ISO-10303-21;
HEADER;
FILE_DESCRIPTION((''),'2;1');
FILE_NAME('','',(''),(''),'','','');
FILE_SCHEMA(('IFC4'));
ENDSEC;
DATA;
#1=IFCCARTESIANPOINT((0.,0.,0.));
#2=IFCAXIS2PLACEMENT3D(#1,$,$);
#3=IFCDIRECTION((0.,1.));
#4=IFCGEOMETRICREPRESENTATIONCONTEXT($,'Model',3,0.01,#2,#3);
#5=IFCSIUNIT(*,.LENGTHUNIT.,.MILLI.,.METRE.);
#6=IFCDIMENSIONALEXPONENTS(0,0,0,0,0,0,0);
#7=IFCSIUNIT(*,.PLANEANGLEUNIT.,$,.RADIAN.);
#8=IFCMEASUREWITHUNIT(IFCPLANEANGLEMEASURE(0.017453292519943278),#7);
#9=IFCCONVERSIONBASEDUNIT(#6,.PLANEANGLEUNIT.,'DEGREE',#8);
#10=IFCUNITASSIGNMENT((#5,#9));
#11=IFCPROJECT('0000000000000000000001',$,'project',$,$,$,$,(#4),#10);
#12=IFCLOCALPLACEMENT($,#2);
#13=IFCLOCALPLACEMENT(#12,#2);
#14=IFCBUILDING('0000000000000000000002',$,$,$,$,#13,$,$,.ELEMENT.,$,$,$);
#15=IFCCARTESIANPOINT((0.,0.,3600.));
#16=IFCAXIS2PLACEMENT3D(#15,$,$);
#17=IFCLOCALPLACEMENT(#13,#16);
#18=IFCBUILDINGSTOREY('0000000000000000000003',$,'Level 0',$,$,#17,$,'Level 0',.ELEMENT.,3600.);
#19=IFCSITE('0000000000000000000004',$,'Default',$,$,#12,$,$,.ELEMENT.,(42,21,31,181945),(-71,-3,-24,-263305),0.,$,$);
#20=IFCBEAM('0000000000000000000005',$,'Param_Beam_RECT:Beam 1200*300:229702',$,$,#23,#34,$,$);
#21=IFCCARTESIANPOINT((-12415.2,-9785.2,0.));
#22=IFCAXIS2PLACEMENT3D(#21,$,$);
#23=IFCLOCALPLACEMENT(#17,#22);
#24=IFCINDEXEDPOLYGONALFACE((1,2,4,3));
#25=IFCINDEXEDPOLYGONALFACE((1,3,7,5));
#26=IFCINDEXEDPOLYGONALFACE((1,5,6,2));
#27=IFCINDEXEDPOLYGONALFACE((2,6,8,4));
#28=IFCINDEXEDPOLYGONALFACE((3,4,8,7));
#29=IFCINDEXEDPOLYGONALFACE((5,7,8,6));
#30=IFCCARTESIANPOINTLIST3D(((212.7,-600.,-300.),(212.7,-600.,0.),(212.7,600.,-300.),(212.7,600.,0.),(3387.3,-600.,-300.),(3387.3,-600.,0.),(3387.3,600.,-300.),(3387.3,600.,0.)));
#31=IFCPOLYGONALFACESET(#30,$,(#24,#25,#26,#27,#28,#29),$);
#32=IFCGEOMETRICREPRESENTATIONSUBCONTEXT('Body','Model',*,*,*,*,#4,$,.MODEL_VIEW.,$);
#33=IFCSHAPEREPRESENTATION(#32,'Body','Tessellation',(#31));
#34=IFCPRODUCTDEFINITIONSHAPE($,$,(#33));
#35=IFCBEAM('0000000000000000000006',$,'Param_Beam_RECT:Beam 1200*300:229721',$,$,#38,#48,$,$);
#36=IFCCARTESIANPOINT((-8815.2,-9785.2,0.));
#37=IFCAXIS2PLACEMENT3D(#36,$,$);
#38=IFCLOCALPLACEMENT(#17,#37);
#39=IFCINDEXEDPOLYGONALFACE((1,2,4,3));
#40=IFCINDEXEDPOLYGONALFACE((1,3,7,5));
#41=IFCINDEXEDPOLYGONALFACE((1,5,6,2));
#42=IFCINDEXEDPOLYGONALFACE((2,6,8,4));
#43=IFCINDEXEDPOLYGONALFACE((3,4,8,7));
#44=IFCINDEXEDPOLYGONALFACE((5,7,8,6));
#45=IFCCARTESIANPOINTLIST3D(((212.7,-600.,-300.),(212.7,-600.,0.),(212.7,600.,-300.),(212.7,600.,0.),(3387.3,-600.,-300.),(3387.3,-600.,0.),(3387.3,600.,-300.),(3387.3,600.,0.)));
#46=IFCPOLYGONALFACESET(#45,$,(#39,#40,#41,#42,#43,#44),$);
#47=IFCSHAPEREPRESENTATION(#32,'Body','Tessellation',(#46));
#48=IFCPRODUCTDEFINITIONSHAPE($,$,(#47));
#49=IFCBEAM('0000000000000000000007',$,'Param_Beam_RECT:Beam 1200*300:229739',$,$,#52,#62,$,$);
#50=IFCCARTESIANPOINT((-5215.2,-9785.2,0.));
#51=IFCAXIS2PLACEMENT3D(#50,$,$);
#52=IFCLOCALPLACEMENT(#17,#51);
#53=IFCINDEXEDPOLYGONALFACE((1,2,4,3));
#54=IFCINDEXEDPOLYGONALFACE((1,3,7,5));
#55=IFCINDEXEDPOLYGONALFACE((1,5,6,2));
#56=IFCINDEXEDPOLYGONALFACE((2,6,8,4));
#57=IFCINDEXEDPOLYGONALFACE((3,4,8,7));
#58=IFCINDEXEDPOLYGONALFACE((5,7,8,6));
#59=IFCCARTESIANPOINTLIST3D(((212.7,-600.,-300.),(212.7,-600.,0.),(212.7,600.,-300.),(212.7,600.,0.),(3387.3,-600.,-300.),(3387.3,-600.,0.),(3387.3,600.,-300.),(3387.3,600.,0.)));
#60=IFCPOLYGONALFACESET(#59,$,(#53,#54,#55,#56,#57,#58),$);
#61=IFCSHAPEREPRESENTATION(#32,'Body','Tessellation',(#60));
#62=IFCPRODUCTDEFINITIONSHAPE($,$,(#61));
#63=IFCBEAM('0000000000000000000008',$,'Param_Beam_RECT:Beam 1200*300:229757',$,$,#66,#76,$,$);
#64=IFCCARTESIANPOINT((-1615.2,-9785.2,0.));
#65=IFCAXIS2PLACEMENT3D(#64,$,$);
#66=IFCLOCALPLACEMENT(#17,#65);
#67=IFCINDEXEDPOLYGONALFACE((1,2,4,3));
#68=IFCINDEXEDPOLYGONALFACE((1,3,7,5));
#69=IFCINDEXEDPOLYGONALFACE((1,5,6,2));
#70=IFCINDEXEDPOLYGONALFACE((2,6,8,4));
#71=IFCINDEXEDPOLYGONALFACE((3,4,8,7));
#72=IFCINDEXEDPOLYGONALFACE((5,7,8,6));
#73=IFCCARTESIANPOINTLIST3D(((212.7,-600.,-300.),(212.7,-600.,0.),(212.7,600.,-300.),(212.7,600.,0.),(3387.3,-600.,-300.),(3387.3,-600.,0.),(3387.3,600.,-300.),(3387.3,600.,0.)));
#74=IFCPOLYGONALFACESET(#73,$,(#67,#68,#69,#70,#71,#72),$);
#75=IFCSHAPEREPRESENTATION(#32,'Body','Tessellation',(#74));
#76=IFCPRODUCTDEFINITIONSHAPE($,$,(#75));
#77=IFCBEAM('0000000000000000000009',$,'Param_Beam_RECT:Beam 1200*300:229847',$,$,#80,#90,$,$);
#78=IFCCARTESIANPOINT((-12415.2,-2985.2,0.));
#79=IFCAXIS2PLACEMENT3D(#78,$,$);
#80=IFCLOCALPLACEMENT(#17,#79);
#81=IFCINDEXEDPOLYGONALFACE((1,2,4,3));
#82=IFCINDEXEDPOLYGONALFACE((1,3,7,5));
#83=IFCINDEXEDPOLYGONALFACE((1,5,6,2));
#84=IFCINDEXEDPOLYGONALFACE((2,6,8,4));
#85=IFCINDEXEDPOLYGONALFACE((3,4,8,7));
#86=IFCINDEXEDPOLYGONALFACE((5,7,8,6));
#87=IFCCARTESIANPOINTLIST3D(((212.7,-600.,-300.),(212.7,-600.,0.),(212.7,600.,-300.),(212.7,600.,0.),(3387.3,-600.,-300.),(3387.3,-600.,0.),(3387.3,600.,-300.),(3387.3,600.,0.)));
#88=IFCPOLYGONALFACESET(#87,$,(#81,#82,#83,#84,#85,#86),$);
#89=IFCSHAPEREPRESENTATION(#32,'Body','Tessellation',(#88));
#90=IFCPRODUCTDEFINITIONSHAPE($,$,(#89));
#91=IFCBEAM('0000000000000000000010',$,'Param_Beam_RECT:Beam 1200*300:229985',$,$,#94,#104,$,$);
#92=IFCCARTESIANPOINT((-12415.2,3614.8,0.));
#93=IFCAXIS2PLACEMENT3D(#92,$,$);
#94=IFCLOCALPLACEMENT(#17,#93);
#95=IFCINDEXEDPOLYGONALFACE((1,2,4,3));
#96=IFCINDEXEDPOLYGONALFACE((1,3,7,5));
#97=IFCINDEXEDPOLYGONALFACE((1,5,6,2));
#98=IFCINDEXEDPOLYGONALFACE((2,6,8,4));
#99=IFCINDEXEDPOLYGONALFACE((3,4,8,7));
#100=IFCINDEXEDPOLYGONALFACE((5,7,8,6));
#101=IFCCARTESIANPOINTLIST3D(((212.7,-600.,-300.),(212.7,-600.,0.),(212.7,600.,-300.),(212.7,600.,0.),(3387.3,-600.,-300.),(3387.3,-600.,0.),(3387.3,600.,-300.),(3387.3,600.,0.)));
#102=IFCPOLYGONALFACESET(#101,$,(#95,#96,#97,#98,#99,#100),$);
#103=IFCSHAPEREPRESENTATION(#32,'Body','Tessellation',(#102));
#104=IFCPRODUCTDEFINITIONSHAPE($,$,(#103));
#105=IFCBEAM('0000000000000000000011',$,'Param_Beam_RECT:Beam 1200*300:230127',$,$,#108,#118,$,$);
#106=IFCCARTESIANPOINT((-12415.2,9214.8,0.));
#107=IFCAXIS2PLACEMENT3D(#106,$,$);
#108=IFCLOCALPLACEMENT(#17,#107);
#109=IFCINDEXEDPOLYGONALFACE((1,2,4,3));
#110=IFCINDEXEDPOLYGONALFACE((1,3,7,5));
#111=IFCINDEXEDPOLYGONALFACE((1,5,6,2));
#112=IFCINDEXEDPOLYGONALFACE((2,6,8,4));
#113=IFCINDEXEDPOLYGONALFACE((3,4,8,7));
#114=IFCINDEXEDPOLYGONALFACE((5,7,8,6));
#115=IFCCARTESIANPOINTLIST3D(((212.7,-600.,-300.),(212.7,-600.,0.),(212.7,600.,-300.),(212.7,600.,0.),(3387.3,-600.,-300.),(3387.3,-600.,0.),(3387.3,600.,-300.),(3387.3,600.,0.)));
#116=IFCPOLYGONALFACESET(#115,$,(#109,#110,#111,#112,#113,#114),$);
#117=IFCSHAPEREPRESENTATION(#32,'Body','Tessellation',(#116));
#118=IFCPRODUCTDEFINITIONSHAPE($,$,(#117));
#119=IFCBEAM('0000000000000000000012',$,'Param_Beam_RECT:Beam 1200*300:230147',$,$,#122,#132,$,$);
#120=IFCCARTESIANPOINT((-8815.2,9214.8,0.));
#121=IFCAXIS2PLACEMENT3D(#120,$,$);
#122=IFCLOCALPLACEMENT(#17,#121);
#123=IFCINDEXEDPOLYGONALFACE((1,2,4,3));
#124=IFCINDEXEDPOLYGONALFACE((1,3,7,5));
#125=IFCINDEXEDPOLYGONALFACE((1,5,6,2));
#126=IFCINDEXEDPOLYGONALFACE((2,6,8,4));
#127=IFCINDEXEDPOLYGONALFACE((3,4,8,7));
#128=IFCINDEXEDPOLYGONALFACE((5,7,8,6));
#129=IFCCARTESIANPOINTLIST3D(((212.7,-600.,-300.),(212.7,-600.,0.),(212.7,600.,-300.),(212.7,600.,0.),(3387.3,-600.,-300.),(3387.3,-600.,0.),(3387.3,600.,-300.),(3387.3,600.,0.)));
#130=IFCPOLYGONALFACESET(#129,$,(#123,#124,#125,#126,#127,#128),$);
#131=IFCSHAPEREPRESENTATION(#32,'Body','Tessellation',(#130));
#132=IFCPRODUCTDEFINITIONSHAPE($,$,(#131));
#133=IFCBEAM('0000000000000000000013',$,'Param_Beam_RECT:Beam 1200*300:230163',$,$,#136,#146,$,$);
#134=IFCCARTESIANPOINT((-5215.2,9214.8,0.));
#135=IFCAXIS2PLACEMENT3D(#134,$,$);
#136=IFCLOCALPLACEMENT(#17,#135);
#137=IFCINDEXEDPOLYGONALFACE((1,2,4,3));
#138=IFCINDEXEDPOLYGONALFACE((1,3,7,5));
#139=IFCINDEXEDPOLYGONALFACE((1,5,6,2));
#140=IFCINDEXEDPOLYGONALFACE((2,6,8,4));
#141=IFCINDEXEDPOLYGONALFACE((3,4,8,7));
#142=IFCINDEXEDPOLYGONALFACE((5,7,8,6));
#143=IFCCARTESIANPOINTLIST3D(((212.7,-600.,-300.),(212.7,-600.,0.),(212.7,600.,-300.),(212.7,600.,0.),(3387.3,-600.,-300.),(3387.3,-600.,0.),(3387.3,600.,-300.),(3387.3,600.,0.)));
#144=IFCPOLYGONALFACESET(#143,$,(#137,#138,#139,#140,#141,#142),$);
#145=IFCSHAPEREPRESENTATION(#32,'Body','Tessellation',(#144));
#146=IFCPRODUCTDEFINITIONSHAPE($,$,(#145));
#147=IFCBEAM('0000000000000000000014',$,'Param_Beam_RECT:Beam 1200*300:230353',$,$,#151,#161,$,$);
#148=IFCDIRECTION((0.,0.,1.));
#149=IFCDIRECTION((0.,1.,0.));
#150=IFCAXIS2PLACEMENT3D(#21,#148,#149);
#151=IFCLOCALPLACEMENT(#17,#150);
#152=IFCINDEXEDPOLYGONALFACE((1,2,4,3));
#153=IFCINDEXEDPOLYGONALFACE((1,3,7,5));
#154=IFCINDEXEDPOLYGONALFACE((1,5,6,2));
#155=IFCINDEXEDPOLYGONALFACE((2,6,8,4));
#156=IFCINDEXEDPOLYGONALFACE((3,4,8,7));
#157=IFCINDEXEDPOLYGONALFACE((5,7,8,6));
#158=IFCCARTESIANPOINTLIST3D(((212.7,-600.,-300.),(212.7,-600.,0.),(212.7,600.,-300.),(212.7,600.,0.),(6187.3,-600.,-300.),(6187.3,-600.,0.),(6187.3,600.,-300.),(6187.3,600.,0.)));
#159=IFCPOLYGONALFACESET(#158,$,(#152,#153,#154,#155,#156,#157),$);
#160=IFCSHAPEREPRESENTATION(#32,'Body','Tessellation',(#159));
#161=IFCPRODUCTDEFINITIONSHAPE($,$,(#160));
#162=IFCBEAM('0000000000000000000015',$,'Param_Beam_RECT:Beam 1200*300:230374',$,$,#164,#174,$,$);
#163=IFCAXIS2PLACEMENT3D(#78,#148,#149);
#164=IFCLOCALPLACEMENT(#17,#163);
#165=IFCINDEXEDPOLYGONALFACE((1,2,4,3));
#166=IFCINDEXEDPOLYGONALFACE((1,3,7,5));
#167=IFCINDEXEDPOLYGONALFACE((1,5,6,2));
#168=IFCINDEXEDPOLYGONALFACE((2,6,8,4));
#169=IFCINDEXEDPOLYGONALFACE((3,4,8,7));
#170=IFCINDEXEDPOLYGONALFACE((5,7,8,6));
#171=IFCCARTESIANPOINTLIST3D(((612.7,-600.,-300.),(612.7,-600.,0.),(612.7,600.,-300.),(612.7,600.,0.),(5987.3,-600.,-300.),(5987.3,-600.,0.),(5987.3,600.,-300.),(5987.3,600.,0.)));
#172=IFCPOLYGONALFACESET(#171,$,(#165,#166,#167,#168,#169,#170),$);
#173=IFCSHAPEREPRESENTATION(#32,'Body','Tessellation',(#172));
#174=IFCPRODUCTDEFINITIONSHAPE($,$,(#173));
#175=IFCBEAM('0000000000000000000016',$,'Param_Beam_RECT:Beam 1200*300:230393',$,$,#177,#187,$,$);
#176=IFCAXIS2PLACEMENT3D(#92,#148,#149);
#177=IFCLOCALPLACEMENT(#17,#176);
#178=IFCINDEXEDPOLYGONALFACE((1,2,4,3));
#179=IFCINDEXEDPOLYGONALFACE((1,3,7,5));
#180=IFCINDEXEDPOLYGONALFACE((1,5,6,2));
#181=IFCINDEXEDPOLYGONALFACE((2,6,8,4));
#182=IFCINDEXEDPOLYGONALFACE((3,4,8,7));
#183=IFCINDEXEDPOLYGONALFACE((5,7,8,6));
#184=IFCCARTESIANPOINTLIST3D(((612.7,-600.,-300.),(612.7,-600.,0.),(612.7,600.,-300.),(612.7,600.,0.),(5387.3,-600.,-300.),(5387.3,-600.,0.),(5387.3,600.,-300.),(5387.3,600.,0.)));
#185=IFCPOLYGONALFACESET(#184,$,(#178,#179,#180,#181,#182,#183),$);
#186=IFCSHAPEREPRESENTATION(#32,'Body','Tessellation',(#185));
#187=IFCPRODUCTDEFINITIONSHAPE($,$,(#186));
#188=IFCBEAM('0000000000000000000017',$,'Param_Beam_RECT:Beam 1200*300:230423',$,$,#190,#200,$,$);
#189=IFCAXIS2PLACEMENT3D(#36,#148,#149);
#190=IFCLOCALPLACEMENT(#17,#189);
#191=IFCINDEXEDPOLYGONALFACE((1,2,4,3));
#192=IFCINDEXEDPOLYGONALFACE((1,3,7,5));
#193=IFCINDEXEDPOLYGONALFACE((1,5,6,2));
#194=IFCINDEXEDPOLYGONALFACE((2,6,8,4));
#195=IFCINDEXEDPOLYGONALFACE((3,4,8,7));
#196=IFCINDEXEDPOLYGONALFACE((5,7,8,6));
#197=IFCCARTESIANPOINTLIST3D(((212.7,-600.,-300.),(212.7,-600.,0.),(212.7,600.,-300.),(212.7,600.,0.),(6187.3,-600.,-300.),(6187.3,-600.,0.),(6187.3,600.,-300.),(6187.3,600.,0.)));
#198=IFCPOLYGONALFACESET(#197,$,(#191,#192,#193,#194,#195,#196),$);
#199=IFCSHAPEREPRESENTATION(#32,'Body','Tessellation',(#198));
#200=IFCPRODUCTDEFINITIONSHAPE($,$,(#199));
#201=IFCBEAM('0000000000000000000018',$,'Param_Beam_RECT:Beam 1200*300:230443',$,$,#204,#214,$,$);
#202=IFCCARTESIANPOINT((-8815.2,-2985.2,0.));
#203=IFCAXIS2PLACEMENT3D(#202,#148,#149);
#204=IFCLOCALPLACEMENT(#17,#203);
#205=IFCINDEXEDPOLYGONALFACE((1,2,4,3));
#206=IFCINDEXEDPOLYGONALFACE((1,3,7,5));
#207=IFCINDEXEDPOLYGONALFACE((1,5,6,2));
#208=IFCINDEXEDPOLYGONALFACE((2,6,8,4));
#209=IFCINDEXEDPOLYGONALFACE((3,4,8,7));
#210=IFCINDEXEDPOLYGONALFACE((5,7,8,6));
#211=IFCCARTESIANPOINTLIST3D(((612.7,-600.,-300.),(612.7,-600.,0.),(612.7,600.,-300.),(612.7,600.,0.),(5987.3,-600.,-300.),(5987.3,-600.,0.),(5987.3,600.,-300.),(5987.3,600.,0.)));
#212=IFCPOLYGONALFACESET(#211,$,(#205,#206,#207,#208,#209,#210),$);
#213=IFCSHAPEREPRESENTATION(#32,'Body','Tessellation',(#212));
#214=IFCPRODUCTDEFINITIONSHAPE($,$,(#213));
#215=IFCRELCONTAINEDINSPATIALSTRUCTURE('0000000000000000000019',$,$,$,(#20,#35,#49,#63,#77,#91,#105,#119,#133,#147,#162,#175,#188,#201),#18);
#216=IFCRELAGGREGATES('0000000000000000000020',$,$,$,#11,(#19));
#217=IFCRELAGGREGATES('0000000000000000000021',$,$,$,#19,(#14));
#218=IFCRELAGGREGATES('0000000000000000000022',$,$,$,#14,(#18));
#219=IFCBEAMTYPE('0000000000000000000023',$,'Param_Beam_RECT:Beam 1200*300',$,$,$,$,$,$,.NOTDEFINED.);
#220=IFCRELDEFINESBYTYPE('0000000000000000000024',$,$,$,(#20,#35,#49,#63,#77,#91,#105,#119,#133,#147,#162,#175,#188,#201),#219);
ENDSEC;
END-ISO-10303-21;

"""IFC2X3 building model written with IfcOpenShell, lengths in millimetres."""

from ifc_helpers import new_model, entity, si_unit, converted_unit, direction, frame, frame_2d, origin, place, context, subcontext, project, spatial, rectangle, extrude, type_object, element, save


model = new_model("IFC2X3")

# Units and contexts
model_context = context("Model", 3, precision=0.01, world=origin(), true_north=direction((0.0, 1.0)))
body_context = subcontext(model_context, "Body", "Model", "MODEL_VIEW")
ifc_project = project(units=[si_unit("LENGTHUNIT", "METRE", prefix="MILLI"), converted_unit("PLANEANGLEUNIT", "DEGREE", entity("IfcPlaneAngleMeasure", 0.017453292519943278), si_unit("PLANEANGLEUNIT", "RADIAN"), dimensions=[0, 0, 0, 0, 0, 0, 0])], contexts=[model_context])

# Site, building, storey
site_placement = place(None, origin())
site = spatial("IfcSite", under=ifc_project, at=site_placement, Name="Default", CompositionType="ELEMENT", RefLatitude=(42, 21, 31, 181945), RefLongitude=(-71, -3, -24, -263305), RefElevation=0.0)
building_placement = place(site_placement, origin())
building = spatial("IfcBuilding", under=site, at=building_placement, CompositionType="ELEMENT")
storey_placement = place(building_placement, frame((0.0, 0.0, 3600.0)))
storey = spatial("IfcBuildingStorey", under=building, at=storey_placement, Name="Level 0", LongName="Level 0", CompositionType="ELEMENT", Elevation=3600.0)

# Beams
beam_type_1 = type_object("IfcBeamType", Name="Param_Beam_RECT:Beam 1200*300", PredefinedType="NOTDEFINED")
beam_1_placement = place(storey_placement, frame((-12415.2, -9785.2, 0.0)))
element("IfcBeam", 1, at=beam_1_placement, inside=storey, type_object=beam_type_1, Name="Param_Beam_RECT:Beam 1200*300:229702", context=body_context, shape_type="SweptSolid", body=[
    extrude(rectangle(XDim=300.0, YDim=1200.0, at=frame_2d((0.0, 0.0), x_axis=(1.0, 0.0))), frame((212.7, 0.0, -150.0), z_axis=(1.0, 0.0, 0.0), x_axis=(0.0, 0.0, -1.0)), (0.0, 0.0, 1.0), 3174.6),
])
beam_2_placement = place(storey_placement, frame((-8815.2, -9785.2, 0.0)))
element("IfcBeam", 2, at=beam_2_placement, inside=storey, type_object=beam_type_1, Name="Param_Beam_RECT:Beam 1200*300:229721", context=body_context, shape_type="SweptSolid", body=[
    extrude(rectangle(XDim=300.0, YDim=1200.0, at=frame_2d((0.0, 0.0), x_axis=(1.0, 0.0))), frame((212.7, 0.0, -150.0), z_axis=(1.0, 0.0, 0.0), x_axis=(0.0, 0.0, -1.0)), (0.0, 0.0, 1.0), 3174.6),
])
beam_3_placement = place(storey_placement, frame((-5215.2, -9785.2, 0.0)))
element("IfcBeam", 3, at=beam_3_placement, inside=storey, type_object=beam_type_1, Name="Param_Beam_RECT:Beam 1200*300:229739", context=body_context, shape_type="SweptSolid", body=[
    extrude(rectangle(XDim=300.0, YDim=1200.0, at=frame_2d((0.0, 0.0), x_axis=(1.0, 0.0))), frame((212.7, 0.0, -150.0), z_axis=(1.0, 0.0, 0.0), x_axis=(0.0, 0.0, -1.0)), (0.0, 0.0, 1.0), 3174.6),
])
beam_4_placement = place(storey_placement, frame((-1615.2, -9785.2, 0.0)))
element("IfcBeam", 4, at=beam_4_placement, inside=storey, type_object=beam_type_1, Name="Param_Beam_RECT:Beam 1200*300:229757", context=body_context, shape_type="SweptSolid", body=[
    extrude(rectangle(XDim=300.0, YDim=1200.0, at=frame_2d((0.0, 0.0), x_axis=(1.0, 0.0))), frame((212.7, 0.0, -150.0), z_axis=(1.0, 0.0, 0.0), x_axis=(0.0, 0.0, -1.0)), (0.0, 0.0, 1.0), 3174.6),
])
beam_5_placement = place(storey_placement, frame((-12415.2, -2985.2, 0.0)))
element("IfcBeam", 5, at=beam_5_placement, inside=storey, type_object=beam_type_1, Name="Param_Beam_RECT:Beam 1200*300:229847", context=body_context, shape_type="SweptSolid", body=[
    extrude(rectangle(XDim=300.0, YDim=1200.0, at=frame_2d((0.0, 0.0), x_axis=(1.0, 0.0))), frame((212.7, 0.0, -150.0), z_axis=(1.0, 0.0, 0.0), x_axis=(0.0, 0.0, -1.0)), (0.0, 0.0, 1.0), 3174.6),
])
beam_6_placement = place(storey_placement, frame((-12415.2, 3614.8, 0.0)))
element("IfcBeam", 6, at=beam_6_placement, inside=storey, type_object=beam_type_1, Name="Param_Beam_RECT:Beam 1200*300:229985", context=body_context, shape_type="SweptSolid", body=[
    extrude(rectangle(XDim=300.0, YDim=1200.0, at=frame_2d((0.0, 0.0), x_axis=(1.0, 0.0))), frame((212.7, 0.0, -150.0), z_axis=(1.0, 0.0, 0.0), x_axis=(0.0, 0.0, -1.0)), (0.0, 0.0, 1.0), 3174.6),
])
beam_7_placement = place(storey_placement, frame((-12415.2, 9214.8, 0.0)))
element("IfcBeam", 7, at=beam_7_placement, inside=storey, type_object=beam_type_1, Name="Param_Beam_RECT:Beam 1200*300:230127", context=body_context, shape_type="SweptSolid", body=[
    extrude(rectangle(XDim=300.0, YDim=1200.0, at=frame_2d((0.0, 0.0), x_axis=(1.0, 0.0))), frame((212.7, 0.0, -150.0), z_axis=(1.0, 0.0, 0.0), x_axis=(0.0, 0.0, -1.0)), (0.0, 0.0, 1.0), 3174.6),
])
for number, where, name in (
    (8, (-8815.2, 9214.8, 0.0), "Param_Beam_RECT:Beam 1200*300:230147"),
    (9, (-5215.2, 9214.8, 0.0), "Param_Beam_RECT:Beam 1200*300:230163"),
):
    element("IfcBeam", number, at=place(storey_placement, frame(where)), inside=storey, type_object=beam_type_1, Name=name, context=body_context, shape_type="SweptSolid", body=[
        extrude(rectangle(XDim=300.0, YDim=1200.0, at=frame_2d((0.0, 0.0), x_axis=(1.0, 0.0))), frame((212.7, 0.0, -150.0), z_axis=(1.0, 0.0, 0.0), x_axis=(0.0, 0.0, -1.0)), (0.0, 0.0, 1.0), 3174.6),
    ])
beam_8_placement = place(storey_placement, frame((-12415.2, -9785.2, 0.0), z_axis=(0.0, 0.0, 1.0), x_axis=(0.0, 1.0, 0.0)))
element("IfcBeam", 10, at=beam_8_placement, inside=storey, type_object=beam_type_1, Name="Param_Beam_RECT:Beam 1200*300:230353", context=body_context, shape_type="SweptSolid", body=[
    extrude(rectangle(XDim=300.0, YDim=1200.0, at=frame_2d((0.0, 0.0), x_axis=(1.0, 0.0))), frame((212.7, 0.0, -150.0), z_axis=(1.0, 0.0, 0.0), x_axis=(0.0, 0.0, -1.0)), (0.0, 0.0, 1.0), 5974.6),
])
beam_9_placement = place(storey_placement, frame((-12415.2, -2985.2, 0.0), z_axis=(0.0, 0.0, 1.0), x_axis=(0.0, 1.0, 0.0)))
element("IfcBeam", 11, at=beam_9_placement, inside=storey, type_object=beam_type_1, Name="Param_Beam_RECT:Beam 1200*300:230374", context=body_context, shape_type="SweptSolid", body=[
    extrude(rectangle(XDim=300.0, YDim=1200.0, at=frame_2d((0.0, 0.0), x_axis=(1.0, 0.0))), frame((612.7, 0.0, -150.0), z_axis=(1.0, 0.0, 0.0), x_axis=(0.0, 0.0, -1.0)), (0.0, 0.0, 1.0), 5374.6),
])
beam_10_placement = place(storey_placement, frame((-12415.2, 3614.8, 0.0), z_axis=(0.0, 0.0, 1.0), x_axis=(0.0, 1.0, 0.0)))
element("IfcBeam", 12, at=beam_10_placement, inside=storey, type_object=beam_type_1, Name="Param_Beam_RECT:Beam 1200*300:230393", context=body_context, shape_type="SweptSolid", body=[
    extrude(rectangle(XDim=300.0, YDim=1200.0, at=frame_2d((0.0, 0.0), x_axis=(1.0, 0.0))), frame((612.7, 0.0, -150.0), z_axis=(1.0, 0.0, 0.0), x_axis=(0.0, 0.0, -1.0)), (0.0, 0.0, 1.0), 4774.6),
])
beam_11_placement = place(storey_placement, frame((-8815.2, -9785.2, 0.0), z_axis=(0.0, 0.0, 1.0), x_axis=(0.0, 1.0, 0.0)))
element("IfcBeam", 13, at=beam_11_placement, inside=storey, type_object=beam_type_1, Name="Param_Beam_RECT:Beam 1200*300:230423", context=body_context, shape_type="SweptSolid", body=[
    extrude(rectangle(XDim=300.0, YDim=1200.0, at=frame_2d((0.0, 0.0), x_axis=(1.0, 0.0))), frame((212.7, 0.0, -150.0), z_axis=(1.0, 0.0, 0.0), x_axis=(0.0, 0.0, -1.0)), (0.0, 0.0, 1.0), 5974.6),
])
beam_12_placement = place(storey_placement, frame((-8815.2, -2985.2, 0.0), z_axis=(0.0, 0.0, 1.0), x_axis=(0.0, 1.0, 0.0)))
element("IfcBeam", 14, at=beam_12_placement, inside=storey, type_object=beam_type_1, Name="Param_Beam_RECT:Beam 1200*300:230443", context=body_context, shape_type="SweptSolid", body=[
    extrude(rectangle(XDim=300.0, YDim=1200.0, at=frame_2d((0.0, 0.0), x_axis=(1.0, 0.0))), frame((612.7, 0.0, -150.0), z_axis=(1.0, 0.0, 0.0), x_axis=(0.0, 0.0, -1.0)), (0.0, 0.0, 1.0), 5374.6),
])

save(model, "model.ifc")
